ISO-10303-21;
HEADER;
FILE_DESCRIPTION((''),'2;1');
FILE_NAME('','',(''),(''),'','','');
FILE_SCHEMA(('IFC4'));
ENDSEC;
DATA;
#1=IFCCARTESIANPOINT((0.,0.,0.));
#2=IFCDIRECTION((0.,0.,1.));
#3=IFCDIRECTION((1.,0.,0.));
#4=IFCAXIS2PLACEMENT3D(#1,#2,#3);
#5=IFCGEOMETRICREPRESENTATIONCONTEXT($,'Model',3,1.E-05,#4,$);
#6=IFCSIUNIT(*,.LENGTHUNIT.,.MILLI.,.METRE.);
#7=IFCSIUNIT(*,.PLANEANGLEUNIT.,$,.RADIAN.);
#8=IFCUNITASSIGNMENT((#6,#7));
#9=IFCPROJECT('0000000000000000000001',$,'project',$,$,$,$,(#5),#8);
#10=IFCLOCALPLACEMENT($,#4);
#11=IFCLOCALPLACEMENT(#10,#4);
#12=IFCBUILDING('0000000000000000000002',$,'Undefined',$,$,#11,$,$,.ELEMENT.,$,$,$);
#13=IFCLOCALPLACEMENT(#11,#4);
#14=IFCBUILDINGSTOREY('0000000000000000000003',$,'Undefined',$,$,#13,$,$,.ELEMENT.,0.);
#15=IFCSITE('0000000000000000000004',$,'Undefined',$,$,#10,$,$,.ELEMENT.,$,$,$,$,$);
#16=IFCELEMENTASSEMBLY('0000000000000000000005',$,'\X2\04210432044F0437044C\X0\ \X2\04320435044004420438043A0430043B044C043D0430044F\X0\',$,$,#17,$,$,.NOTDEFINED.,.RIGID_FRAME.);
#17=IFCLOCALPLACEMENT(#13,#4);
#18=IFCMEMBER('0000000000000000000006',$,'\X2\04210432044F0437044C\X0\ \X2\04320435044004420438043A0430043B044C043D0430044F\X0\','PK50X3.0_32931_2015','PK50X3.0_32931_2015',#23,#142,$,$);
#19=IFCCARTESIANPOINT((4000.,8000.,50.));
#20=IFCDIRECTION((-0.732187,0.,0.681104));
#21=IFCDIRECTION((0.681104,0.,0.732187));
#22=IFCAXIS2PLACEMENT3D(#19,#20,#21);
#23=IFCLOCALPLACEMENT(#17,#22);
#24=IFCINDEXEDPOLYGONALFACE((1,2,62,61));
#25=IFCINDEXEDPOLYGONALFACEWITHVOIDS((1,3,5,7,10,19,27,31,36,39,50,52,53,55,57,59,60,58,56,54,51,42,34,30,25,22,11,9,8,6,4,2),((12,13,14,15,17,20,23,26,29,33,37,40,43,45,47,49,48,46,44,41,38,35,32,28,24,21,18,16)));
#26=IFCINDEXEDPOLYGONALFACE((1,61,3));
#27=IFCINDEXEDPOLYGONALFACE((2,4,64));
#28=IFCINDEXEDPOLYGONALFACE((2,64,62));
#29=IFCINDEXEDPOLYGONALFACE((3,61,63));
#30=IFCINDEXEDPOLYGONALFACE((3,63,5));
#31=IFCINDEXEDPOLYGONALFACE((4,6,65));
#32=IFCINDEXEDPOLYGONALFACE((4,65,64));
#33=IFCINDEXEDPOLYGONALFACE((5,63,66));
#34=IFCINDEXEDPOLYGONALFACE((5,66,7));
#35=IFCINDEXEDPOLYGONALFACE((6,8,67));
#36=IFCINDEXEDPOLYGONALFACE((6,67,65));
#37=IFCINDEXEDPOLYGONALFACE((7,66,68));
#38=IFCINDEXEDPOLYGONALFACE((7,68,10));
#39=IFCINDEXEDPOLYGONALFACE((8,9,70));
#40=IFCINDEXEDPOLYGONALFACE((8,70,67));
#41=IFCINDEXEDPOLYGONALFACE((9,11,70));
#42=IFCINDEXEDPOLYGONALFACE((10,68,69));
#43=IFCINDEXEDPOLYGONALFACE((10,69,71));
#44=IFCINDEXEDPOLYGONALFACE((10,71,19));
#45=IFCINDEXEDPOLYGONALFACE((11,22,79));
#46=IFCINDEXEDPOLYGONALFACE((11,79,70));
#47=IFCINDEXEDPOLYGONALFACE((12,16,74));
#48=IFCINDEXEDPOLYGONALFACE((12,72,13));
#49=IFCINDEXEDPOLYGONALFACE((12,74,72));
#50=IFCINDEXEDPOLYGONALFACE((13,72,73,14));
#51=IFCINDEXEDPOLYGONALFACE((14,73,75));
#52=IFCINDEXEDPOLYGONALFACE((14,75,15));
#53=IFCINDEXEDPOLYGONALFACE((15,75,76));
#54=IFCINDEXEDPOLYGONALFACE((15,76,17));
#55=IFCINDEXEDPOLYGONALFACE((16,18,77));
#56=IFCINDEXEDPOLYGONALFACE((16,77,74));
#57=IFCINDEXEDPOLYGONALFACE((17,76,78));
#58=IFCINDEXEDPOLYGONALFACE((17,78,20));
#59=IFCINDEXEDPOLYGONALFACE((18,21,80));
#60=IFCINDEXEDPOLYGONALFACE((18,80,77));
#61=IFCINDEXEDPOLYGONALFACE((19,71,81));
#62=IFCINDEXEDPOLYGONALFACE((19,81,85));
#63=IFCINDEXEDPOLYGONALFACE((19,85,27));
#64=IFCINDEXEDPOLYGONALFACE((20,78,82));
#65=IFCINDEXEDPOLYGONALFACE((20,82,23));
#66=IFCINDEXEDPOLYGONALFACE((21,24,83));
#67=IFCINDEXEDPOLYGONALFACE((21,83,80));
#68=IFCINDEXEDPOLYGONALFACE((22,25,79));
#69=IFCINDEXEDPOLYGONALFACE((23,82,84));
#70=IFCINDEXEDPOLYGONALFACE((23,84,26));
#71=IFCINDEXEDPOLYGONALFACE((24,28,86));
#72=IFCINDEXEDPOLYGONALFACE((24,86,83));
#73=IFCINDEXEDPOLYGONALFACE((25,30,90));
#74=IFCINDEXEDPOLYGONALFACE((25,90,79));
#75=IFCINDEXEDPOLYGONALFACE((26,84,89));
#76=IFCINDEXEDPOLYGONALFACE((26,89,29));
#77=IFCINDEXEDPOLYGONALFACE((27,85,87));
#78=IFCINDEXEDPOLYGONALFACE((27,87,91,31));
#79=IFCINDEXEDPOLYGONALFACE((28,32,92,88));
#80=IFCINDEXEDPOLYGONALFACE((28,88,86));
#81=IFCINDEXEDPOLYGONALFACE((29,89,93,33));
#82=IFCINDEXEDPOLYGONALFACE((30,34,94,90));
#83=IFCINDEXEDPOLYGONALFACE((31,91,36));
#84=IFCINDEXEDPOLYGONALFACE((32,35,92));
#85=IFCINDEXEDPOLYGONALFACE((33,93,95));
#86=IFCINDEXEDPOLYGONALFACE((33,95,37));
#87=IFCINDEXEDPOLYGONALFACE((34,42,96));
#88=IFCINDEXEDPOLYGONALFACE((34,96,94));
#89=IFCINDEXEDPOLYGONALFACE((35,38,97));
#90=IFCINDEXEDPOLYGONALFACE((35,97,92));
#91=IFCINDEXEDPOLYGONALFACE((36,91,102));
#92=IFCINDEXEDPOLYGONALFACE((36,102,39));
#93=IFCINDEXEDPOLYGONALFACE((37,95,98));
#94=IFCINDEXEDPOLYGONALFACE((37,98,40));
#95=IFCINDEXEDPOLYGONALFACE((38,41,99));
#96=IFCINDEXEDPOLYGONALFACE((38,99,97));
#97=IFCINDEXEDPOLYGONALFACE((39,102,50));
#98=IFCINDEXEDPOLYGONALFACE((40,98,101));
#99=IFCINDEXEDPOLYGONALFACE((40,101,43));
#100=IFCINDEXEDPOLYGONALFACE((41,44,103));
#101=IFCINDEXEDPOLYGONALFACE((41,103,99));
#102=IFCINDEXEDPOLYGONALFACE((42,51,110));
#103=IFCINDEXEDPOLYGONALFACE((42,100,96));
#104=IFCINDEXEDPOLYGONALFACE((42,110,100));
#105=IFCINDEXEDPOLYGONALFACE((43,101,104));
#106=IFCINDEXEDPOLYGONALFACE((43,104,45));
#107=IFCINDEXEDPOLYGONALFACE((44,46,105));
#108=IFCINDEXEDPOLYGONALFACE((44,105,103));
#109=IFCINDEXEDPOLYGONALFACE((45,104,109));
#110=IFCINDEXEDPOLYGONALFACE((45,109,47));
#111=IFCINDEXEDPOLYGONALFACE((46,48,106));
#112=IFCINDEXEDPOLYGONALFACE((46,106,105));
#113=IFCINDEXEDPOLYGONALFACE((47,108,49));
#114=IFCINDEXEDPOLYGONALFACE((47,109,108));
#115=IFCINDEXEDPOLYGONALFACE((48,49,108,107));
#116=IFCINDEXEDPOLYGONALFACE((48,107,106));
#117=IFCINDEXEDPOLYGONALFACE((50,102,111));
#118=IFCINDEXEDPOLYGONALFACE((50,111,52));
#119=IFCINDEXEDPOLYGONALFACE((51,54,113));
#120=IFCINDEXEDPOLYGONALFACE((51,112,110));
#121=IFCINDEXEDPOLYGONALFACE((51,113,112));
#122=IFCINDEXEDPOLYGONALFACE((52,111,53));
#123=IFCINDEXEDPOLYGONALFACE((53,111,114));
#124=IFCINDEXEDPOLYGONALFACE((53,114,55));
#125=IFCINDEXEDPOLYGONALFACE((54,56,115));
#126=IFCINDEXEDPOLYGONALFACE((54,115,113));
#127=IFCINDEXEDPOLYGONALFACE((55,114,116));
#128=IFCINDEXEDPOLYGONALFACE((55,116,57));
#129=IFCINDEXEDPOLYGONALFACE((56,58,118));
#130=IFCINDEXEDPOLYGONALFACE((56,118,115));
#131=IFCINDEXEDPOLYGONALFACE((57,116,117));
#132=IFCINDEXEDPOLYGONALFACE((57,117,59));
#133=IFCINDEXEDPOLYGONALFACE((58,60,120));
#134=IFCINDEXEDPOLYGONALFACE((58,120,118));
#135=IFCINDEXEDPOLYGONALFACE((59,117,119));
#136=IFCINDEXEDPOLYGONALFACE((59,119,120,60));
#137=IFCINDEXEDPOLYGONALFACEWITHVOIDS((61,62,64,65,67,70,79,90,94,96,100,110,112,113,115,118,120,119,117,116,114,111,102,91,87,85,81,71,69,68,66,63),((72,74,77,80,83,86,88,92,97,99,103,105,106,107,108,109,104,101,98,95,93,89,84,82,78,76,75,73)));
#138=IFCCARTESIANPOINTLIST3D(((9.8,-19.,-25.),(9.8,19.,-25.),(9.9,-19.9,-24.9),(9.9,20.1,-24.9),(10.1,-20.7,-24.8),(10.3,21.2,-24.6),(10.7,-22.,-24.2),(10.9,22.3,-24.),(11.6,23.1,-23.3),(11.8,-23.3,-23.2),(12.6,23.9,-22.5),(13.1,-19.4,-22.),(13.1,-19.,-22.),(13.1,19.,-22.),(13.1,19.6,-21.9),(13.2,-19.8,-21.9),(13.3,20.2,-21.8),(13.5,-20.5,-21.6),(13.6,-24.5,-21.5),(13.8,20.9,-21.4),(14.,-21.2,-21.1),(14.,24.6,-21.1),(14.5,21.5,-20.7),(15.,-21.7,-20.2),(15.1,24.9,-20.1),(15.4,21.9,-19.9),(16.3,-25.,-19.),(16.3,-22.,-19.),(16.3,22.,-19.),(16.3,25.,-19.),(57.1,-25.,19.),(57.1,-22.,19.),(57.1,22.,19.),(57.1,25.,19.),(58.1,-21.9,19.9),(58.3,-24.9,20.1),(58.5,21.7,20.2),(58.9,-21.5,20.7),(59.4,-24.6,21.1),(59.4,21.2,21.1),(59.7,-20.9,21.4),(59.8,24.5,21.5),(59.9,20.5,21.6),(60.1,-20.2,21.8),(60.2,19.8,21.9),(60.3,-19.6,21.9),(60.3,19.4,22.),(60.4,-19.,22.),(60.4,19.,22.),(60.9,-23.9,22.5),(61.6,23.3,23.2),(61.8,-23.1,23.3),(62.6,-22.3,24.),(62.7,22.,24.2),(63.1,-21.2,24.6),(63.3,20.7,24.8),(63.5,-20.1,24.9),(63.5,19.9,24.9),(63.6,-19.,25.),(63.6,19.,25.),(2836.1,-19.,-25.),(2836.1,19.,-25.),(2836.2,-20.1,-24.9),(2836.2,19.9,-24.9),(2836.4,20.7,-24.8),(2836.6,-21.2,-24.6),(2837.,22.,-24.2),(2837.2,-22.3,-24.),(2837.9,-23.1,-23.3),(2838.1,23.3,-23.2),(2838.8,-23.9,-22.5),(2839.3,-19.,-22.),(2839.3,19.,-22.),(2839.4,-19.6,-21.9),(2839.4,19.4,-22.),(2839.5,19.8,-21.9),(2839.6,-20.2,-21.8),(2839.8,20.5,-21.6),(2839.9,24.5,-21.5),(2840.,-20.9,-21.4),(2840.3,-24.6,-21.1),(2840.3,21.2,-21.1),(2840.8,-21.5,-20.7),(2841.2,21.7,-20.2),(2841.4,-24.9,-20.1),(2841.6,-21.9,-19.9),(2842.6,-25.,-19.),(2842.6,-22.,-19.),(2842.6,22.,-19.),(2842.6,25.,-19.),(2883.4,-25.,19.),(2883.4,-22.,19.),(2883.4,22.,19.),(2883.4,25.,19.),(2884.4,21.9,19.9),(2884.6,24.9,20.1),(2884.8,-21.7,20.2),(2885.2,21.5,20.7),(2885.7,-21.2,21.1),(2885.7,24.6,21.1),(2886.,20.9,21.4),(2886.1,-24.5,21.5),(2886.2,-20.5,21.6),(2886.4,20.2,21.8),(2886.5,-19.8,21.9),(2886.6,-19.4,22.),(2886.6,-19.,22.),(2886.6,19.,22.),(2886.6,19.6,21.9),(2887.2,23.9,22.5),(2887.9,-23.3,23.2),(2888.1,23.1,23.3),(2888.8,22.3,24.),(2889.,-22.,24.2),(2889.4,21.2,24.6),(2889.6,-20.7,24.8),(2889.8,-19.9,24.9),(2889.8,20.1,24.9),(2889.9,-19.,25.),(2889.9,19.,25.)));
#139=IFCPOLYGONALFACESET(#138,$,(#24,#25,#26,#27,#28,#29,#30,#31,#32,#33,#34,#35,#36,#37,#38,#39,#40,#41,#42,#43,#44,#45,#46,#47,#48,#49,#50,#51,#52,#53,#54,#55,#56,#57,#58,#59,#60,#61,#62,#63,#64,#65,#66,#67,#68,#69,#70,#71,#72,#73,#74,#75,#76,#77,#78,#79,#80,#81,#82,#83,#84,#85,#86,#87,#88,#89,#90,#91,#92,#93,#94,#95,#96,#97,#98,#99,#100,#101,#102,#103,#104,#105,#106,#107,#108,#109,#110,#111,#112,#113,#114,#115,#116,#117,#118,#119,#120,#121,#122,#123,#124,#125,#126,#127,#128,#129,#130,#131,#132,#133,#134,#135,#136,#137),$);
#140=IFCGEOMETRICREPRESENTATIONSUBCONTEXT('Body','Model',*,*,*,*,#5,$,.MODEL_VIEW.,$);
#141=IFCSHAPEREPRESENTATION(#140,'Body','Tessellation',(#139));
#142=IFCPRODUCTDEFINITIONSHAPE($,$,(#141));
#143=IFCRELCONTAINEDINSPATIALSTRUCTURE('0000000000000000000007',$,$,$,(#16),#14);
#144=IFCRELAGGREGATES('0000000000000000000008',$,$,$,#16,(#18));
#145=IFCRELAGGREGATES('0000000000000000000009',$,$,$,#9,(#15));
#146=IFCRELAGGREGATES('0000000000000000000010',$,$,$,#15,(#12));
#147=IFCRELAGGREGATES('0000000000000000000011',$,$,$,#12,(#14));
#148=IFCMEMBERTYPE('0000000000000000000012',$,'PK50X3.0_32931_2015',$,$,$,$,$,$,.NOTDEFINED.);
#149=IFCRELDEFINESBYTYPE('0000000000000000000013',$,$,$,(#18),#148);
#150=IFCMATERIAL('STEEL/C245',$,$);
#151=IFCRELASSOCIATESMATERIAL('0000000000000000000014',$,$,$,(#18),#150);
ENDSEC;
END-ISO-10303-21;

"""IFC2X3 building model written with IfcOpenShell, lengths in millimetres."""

from ifc_helpers import new_model, si_unit, frame, origin_with_axes, origin_2d_with_axis, place, context, subcontext, project, spatial, hollow_rectangle, extrude, clip, halfspace, material, type_object, element, aggregate, save


model = new_model("IFC2X3")

# Units and contexts
model_context = context("Model", 3, precision=1e-05, world=origin_with_axes())
body_context = subcontext(model_context, "Body", "Model", "MODEL_VIEW")
ifc_project = project(units=[si_unit("LENGTHUNIT", "METRE", prefix="MILLI"), si_unit("PLANEANGLEUNIT", "RADIAN")], contexts=[model_context])

# Site, building, storey
site_placement = place(None, origin_with_axes())
site = spatial("IfcSite", under=ifc_project, at=site_placement, Name="Undefined", CompositionType="ELEMENT")
building_placement = place(site_placement, origin_with_axes())
building = spatial("IfcBuilding", under=site, at=building_placement, Name="Undefined", CompositionType="ELEMENT")
storey_placement = place(building_placement, origin_with_axes())
storey = spatial("IfcBuildingStorey", under=building, at=storey_placement, Name="Undefined", CompositionType="ELEMENT", Elevation=0.0)

# Shared definitions
ifc_material_1 = material(Name="STEEL/C245")

# Element assembly, member
assembly_1_placement = place(storey_placement, origin_with_axes())
assembly_1 = element("IfcElementAssembly", 1, at=assembly_1_placement, inside=storey, Name="Связь вертикальная", AssemblyPlace="NOTDEFINED", PredefinedType="RIGID_FRAME")
member_type_1 = type_object("IfcMemberType", Name="PK50X3.0_32931_2015", PredefinedType="NOTDEFINED")
member_1_placement = place(assembly_1_placement, frame((4000.0, 8000.0, 50.0), z_axis=(-0.732187, 0.0, 0.681104), x_axis=(0.681104, 0.0, 0.732187)))
member_1 = element("IfcMember", 2, at=member_1_placement, type_object=member_type_1, material=ifc_material_1, Name="Связь вертикальная", Description="PK50X3.0_32931_2015", ObjectType="PK50X3.0_32931_2015", context=body_context, shape_type="Clipping", body=[
    clip(clip(extrude(hollow_rectangle(XDim=50.0, YDim=50.0, WallThickness=3.0, InnerFilletRadius=3.0, OuterFilletRadius=6.0, at=origin_2d_with_axis()), frame((2917.3, 0.0, 0.0), z_axis=(-1.0, 0.0, 0.0), x_axis=(0.0, -1.0, 0.0)), (0.0, 0.0, 1.0), 2934.9), halfspace(frame((2798.5, 0.0, -60.0), z_axis=(-0.681104, 0.0, 0.732187), x_axis=(0.0, -1.0, 0.0)), True)), halfspace(frame((-25.7, 0.0, -58.0), z_axis=(0.681104, 0.0, -0.732187), x_axis=(0.0, -1.0, 0.0)), True)),
])
aggregate(assembly_1, [member_1])

save(model, "model.ifc")
